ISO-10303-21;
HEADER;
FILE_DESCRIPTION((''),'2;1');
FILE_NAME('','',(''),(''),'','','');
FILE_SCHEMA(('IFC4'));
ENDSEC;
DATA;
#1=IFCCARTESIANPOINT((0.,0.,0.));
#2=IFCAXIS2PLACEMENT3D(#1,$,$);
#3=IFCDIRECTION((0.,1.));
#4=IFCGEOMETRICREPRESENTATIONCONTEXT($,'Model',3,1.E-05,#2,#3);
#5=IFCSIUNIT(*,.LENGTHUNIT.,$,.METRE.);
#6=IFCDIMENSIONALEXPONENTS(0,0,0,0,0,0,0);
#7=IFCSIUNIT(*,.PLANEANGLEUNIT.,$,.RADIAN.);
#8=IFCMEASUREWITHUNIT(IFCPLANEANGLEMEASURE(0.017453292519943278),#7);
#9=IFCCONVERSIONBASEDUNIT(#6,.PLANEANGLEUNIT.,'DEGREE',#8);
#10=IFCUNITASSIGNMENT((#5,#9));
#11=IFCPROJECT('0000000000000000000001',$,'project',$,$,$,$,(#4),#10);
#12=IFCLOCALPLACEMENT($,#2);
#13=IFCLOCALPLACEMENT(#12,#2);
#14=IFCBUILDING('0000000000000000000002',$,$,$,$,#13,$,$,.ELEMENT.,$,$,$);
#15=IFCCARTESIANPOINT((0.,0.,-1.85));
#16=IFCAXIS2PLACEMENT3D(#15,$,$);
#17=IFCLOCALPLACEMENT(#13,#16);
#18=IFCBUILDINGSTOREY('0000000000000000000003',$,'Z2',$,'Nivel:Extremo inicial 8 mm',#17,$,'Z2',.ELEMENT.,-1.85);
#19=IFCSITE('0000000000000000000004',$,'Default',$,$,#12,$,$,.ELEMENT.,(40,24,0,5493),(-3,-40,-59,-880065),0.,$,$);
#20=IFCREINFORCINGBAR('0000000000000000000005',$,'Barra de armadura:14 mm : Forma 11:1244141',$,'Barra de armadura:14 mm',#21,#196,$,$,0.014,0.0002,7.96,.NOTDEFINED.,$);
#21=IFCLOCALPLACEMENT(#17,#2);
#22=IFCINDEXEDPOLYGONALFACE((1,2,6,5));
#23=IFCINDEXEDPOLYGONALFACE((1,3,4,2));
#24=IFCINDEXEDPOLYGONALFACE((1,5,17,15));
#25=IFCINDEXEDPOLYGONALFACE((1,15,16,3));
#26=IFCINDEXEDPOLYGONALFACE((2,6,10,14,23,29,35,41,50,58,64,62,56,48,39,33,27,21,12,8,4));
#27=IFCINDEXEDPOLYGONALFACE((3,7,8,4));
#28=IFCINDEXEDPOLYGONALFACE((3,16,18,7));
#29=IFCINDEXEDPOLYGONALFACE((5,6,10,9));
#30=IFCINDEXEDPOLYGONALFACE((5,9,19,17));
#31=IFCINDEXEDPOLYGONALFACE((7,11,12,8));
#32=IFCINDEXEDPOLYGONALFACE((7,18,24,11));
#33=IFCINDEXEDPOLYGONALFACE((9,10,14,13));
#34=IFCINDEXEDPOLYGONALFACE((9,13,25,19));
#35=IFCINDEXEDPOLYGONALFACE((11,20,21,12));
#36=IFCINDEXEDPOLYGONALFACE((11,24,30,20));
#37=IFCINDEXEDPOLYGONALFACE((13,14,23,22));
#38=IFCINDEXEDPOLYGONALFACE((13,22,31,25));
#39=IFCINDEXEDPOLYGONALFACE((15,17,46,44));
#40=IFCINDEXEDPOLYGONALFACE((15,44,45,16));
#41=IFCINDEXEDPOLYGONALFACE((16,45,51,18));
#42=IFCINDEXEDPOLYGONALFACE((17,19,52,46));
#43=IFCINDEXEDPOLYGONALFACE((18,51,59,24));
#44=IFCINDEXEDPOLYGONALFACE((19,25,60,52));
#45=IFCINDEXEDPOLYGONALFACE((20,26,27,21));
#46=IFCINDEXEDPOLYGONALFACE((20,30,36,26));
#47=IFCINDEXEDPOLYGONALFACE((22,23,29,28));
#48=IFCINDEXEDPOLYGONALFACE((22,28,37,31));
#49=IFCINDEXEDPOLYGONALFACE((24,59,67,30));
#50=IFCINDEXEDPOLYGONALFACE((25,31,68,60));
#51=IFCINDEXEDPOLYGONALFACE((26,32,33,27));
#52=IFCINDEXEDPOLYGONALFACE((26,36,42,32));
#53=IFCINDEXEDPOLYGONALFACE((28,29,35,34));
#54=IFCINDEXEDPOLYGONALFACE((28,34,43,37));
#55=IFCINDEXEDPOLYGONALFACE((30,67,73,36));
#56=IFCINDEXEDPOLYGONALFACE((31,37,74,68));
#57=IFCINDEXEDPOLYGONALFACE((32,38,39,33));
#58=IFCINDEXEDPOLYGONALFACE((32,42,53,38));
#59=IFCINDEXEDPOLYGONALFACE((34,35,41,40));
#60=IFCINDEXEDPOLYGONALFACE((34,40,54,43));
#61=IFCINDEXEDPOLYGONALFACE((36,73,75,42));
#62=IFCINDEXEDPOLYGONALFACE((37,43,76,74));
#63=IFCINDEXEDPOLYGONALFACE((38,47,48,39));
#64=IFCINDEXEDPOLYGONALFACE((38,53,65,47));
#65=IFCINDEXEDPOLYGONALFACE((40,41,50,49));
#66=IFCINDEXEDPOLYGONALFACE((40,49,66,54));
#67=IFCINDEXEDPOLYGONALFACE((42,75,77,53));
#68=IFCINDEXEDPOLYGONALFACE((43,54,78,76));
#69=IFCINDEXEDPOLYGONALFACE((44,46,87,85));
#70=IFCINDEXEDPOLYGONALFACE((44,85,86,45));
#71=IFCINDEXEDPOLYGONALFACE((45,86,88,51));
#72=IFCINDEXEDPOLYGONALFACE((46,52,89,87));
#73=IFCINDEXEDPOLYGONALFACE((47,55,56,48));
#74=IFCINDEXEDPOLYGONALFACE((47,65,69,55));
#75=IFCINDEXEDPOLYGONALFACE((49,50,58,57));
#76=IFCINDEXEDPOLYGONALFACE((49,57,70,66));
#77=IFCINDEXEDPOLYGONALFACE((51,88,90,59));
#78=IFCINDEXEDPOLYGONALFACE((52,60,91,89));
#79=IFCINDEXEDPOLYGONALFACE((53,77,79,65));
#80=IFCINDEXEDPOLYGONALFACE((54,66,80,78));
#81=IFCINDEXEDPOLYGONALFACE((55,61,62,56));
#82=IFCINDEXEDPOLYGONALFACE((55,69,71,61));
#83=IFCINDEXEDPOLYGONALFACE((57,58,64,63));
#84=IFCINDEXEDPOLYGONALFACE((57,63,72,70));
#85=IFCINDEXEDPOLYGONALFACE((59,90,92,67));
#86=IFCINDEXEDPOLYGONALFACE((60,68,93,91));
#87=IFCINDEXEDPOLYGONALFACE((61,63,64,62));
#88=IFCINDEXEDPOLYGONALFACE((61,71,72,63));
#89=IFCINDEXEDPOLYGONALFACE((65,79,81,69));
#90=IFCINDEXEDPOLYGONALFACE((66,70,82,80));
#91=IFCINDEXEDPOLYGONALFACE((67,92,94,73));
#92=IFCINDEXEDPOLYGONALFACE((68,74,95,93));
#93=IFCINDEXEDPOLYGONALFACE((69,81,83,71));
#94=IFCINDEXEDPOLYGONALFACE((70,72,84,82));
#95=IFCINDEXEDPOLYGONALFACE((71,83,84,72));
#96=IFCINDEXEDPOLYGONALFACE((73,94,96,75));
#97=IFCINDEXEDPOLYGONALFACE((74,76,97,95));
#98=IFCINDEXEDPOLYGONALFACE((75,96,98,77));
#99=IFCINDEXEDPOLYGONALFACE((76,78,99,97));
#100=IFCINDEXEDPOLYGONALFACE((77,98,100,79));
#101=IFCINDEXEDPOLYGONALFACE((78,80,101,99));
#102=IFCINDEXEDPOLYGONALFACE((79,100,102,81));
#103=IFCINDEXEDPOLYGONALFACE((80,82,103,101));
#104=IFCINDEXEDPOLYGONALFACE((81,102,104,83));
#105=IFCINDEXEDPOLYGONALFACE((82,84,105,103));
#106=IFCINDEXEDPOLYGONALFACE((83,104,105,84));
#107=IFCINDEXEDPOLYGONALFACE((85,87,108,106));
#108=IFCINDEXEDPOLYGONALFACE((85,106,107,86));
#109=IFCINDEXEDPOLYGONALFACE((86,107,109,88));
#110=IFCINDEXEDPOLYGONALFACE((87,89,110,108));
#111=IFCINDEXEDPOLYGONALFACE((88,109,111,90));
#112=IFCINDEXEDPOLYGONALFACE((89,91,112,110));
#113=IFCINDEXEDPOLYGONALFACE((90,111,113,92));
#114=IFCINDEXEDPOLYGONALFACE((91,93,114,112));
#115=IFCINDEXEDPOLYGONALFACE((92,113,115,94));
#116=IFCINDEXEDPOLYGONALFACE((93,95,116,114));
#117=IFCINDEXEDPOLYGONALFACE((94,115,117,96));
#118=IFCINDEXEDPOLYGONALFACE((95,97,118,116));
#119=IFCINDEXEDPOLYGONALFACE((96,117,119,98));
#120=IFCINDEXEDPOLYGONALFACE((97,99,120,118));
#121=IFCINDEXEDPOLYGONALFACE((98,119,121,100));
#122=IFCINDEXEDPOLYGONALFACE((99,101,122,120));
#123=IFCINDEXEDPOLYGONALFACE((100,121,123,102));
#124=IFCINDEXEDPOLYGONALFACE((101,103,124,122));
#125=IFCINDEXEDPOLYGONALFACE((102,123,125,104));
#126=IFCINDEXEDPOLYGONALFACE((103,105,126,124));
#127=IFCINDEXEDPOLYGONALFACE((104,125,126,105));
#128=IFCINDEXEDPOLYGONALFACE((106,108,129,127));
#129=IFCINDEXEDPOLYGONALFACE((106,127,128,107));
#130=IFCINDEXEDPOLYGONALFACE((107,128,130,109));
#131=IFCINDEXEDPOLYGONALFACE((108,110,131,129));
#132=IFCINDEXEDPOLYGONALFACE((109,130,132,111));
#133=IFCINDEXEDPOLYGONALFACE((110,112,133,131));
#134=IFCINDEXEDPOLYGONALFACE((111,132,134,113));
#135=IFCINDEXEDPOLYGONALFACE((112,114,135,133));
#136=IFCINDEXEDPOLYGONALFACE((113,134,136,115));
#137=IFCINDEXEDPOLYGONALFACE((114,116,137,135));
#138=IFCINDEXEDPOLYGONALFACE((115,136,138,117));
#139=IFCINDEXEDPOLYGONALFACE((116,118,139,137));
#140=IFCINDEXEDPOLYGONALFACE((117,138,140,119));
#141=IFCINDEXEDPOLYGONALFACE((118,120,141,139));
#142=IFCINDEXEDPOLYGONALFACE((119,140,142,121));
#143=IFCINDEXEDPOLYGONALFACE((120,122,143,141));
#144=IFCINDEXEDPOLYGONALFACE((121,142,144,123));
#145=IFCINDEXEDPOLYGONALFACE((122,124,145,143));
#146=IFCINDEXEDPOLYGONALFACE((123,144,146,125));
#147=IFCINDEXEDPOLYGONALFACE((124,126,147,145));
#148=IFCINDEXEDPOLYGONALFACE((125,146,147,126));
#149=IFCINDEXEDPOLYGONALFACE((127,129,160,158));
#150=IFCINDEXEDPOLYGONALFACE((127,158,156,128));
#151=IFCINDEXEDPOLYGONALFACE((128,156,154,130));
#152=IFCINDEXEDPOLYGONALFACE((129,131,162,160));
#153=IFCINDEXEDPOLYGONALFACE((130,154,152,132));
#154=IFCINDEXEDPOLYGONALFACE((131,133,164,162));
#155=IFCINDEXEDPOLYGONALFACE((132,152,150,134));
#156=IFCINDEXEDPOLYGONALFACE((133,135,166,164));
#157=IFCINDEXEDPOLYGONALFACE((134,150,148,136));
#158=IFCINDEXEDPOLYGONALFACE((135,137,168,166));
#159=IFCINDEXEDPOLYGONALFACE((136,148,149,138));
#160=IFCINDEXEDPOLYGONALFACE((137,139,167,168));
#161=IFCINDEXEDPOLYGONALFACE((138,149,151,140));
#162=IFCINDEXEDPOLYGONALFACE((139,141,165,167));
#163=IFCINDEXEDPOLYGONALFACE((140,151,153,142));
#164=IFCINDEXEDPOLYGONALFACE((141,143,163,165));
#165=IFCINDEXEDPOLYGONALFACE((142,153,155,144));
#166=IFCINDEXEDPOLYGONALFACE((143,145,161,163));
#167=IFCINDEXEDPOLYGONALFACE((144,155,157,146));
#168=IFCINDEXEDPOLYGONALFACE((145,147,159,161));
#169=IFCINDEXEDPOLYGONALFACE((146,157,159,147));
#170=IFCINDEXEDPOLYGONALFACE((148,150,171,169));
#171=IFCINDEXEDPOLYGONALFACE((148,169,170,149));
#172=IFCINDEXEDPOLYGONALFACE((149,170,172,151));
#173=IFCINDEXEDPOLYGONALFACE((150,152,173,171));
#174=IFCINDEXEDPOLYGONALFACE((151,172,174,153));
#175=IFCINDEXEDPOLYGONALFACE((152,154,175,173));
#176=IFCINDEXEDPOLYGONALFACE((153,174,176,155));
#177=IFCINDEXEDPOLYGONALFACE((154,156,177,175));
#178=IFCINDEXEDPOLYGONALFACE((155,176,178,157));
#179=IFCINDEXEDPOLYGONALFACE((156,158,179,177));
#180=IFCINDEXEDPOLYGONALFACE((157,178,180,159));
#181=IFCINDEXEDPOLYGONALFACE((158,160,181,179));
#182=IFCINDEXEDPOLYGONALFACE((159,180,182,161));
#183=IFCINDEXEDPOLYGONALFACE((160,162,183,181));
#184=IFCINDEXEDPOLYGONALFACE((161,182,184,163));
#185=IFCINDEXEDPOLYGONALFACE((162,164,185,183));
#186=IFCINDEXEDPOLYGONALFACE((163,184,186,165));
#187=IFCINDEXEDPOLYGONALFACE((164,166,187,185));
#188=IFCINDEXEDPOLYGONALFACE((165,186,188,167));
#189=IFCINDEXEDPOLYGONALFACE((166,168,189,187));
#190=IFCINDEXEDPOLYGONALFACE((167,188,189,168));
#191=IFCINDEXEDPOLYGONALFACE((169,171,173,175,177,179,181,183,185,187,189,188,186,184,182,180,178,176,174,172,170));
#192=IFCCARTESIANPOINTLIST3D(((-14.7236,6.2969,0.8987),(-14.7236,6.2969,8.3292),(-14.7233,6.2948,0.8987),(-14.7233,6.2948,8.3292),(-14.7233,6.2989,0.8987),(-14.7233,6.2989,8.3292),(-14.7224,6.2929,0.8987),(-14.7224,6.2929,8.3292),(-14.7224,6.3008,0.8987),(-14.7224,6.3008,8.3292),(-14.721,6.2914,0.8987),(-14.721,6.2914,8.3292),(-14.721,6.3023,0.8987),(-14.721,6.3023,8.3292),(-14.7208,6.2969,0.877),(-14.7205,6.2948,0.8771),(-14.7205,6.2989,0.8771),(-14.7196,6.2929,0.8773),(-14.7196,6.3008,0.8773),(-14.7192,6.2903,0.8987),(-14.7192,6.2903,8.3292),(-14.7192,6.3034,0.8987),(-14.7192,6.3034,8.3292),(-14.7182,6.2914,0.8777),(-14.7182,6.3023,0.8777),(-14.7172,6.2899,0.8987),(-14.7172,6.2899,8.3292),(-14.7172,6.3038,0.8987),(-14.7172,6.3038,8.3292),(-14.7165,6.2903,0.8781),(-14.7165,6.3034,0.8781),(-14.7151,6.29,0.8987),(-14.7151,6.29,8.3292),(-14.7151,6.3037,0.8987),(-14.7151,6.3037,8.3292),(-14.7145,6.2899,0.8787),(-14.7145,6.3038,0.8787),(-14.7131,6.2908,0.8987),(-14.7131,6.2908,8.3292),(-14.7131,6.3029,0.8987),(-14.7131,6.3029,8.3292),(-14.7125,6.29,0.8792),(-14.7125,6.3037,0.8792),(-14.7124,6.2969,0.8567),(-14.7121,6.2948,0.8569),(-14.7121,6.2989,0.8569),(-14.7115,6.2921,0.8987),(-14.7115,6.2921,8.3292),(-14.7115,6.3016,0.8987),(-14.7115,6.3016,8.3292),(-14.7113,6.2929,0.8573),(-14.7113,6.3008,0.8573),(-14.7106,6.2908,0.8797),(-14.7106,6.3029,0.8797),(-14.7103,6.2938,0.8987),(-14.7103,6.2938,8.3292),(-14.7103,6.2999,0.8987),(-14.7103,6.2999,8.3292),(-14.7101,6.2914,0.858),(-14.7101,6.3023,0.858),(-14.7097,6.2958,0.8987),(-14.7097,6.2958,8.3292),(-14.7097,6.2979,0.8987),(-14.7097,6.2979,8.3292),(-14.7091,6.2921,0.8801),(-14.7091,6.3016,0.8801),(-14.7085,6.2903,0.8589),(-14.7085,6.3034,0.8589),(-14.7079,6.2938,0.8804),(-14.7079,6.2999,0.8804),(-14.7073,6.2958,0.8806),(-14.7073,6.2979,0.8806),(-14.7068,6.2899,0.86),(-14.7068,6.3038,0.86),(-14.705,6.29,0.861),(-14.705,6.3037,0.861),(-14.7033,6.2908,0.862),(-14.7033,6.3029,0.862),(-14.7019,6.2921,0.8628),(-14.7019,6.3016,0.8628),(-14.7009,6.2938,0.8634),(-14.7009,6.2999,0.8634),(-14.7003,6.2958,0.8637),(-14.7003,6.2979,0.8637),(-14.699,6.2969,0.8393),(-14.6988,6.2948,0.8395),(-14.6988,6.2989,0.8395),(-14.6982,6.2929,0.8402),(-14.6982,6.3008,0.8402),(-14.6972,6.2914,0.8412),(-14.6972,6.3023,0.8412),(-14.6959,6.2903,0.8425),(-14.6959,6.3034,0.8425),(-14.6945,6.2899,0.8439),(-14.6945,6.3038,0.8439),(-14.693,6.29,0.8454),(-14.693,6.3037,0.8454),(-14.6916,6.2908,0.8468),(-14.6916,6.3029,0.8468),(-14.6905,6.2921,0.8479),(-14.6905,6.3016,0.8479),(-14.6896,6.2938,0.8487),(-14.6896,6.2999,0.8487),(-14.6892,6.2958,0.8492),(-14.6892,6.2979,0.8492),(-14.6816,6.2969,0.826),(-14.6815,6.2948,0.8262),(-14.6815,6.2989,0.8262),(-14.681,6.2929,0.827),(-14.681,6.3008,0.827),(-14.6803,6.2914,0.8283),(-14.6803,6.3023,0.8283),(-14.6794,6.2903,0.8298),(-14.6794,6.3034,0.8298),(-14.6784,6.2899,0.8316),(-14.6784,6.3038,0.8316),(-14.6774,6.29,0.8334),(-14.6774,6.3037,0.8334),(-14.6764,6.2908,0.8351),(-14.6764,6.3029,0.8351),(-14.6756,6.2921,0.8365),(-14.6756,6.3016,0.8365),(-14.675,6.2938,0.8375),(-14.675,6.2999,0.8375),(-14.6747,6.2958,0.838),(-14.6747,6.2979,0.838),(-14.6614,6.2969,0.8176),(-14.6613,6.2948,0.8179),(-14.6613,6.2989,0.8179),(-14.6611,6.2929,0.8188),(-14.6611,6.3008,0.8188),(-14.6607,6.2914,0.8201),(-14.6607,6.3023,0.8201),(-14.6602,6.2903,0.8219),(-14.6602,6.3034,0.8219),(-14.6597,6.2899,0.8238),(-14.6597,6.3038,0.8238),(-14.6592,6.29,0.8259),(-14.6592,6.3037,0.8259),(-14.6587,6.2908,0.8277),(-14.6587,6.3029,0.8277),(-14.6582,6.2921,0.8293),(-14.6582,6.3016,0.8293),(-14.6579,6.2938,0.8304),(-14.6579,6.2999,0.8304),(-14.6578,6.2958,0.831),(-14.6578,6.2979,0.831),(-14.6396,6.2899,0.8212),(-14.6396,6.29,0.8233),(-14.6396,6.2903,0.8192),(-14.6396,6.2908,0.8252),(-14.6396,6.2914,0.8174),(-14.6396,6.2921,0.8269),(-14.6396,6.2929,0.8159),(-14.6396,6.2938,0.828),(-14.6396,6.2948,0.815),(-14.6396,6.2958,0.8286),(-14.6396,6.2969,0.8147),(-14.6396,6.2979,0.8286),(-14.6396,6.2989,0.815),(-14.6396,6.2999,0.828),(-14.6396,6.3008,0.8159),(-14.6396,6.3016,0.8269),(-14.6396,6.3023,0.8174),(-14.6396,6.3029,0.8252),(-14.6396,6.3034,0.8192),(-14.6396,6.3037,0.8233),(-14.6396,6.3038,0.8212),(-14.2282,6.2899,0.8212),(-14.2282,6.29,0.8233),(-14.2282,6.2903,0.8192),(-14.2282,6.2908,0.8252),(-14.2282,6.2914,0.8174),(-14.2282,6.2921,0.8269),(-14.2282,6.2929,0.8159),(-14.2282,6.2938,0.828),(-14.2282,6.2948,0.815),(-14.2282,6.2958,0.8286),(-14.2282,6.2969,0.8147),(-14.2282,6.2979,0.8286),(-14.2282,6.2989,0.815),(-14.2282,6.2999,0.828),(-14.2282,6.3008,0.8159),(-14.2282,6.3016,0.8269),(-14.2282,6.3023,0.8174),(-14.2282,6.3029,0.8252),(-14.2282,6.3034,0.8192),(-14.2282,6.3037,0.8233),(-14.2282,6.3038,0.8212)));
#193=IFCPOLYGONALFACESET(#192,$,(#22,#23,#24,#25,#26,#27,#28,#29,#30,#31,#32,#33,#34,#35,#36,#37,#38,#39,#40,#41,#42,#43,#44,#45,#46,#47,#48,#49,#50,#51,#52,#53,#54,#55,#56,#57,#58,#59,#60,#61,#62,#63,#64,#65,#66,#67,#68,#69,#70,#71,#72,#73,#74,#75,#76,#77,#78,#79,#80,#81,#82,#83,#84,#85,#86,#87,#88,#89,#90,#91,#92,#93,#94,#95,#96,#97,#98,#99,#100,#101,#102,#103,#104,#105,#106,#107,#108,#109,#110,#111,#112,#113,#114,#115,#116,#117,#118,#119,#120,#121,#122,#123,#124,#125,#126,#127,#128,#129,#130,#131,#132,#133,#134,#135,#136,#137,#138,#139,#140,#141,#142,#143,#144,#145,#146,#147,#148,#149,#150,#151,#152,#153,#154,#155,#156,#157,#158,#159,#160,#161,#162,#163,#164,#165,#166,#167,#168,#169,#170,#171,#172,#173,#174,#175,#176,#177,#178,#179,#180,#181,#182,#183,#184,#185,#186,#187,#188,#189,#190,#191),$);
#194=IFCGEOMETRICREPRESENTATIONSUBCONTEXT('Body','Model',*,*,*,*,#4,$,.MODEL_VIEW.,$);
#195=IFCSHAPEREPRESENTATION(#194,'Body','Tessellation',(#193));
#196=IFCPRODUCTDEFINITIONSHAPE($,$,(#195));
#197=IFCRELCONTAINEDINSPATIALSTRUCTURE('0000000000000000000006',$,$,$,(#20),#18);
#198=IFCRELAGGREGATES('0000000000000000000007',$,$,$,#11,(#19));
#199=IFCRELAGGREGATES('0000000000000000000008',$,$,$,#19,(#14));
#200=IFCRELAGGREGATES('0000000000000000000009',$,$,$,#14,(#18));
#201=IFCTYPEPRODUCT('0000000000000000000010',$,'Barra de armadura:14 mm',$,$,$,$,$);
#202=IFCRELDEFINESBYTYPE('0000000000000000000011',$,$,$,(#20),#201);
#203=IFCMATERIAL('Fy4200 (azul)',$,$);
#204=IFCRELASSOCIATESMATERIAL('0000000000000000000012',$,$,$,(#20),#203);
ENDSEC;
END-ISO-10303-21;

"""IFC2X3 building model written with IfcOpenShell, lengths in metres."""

from ifc_helpers import new_model, entity, si_unit, converted_unit, direction, frame, origin, place, context, subcontext, project, spatial, material, type_object, element, save


model = new_model("IFC2X3")

# Units and contexts
model_context = context("Model", 3, precision=1e-05, world=origin(), true_north=direction((0.0, 1.0)))
body_context = subcontext(model_context, "Body", "Model", "MODEL_VIEW")
ifc_project = project(units=[si_unit("LENGTHUNIT", "METRE"), converted_unit("PLANEANGLEUNIT", "DEGREE", entity("IfcPlaneAngleMeasure", 0.017453292519943278), si_unit("PLANEANGLEUNIT", "RADIAN"), dimensions=[0, 0, 0, 0, 0, 0, 0])], contexts=[model_context])

# Site, building, storey
site_placement = place(None, origin())
site = spatial("IfcSite", under=ifc_project, at=site_placement, Name="Default", CompositionType="ELEMENT", RefLatitude=(40, 24, 0, 5493), RefLongitude=(-3, -40, -59, -880065), RefElevation=0.0)
building_placement = place(site_placement, origin())
building = spatial("IfcBuilding", under=site, at=building_placement, CompositionType="ELEMENT")
storey_placement = place(building_placement, frame((0.0, 0.0, -1.85)))
storey = spatial("IfcBuildingStorey", under=building, at=storey_placement, Name="Z2", ObjectType="Nivel:Extremo inicial 8 mm", LongName="Z2", CompositionType="ELEMENT", Elevation=-1.85)

# Reinforcing bar
ifc_material_1 = material(Name="Fy4200 (azul)")
type_product_1 = type_object("IfcTypeProduct", Name="Barra de armadura:14 mm")
reinforcing_bar_1_placement = place(storey_placement, origin())
element("IfcReinforcingBar", 1, at=reinforcing_bar_1_placement, inside=storey, type_object=type_product_1, material=ifc_material_1, Name="Barra de armadura:14 mm : Forma 11:1244141", ObjectType="Barra de armadura:14 mm", BarLength=7.96, BarRole="NOTDEFINED", CrossSectionArea=0.0002, NominalDiameter=0.014, context=body_context, shape_type="AdvancedSweptSolid", body=[
    entity("IfcSweptDiskSolid", entity("IfcCompositeCurve", [entity("IfcCompositeCurveSegment", "CONTINUOUS", True, entity("IfcPolyline", [entity("IfcCartesianPoint", [-14.7166, 6.2969, 8.3292]), entity("IfcCartesianPoint", [-14.7166, 6.2969, 0.8987])])), entity("IfcCompositeCurveSegment", "CONTINUOUS", True, entity("IfcTrimmedCurve", entity("IfcCircle", entity("IfcAxis2Placement3D", entity("IfcCartesianPoint", [-14.6396, 6.2969, 0.8987]), entity("IfcDirection", [0.0, -1.0, 0.0]), entity("IfcDirection", [0.0, 0.0, -1.0])), 0.077), [entity("IfcParameterValue", 270.0)], [entity("IfcParameterValue", 360.0)], True, "PARAMETER")), entity("IfcCompositeCurveSegment", "CONTINUOUS", True, entity("IfcPolyline", [entity("IfcCartesianPoint", [-14.6396, 6.2969, 0.8217]), entity("IfcCartesianPoint", [-14.2282, 6.2969, 0.8217])]))], False), 0.007, None, 0.0, 92.0),
])

save(model, "model.ifc")
